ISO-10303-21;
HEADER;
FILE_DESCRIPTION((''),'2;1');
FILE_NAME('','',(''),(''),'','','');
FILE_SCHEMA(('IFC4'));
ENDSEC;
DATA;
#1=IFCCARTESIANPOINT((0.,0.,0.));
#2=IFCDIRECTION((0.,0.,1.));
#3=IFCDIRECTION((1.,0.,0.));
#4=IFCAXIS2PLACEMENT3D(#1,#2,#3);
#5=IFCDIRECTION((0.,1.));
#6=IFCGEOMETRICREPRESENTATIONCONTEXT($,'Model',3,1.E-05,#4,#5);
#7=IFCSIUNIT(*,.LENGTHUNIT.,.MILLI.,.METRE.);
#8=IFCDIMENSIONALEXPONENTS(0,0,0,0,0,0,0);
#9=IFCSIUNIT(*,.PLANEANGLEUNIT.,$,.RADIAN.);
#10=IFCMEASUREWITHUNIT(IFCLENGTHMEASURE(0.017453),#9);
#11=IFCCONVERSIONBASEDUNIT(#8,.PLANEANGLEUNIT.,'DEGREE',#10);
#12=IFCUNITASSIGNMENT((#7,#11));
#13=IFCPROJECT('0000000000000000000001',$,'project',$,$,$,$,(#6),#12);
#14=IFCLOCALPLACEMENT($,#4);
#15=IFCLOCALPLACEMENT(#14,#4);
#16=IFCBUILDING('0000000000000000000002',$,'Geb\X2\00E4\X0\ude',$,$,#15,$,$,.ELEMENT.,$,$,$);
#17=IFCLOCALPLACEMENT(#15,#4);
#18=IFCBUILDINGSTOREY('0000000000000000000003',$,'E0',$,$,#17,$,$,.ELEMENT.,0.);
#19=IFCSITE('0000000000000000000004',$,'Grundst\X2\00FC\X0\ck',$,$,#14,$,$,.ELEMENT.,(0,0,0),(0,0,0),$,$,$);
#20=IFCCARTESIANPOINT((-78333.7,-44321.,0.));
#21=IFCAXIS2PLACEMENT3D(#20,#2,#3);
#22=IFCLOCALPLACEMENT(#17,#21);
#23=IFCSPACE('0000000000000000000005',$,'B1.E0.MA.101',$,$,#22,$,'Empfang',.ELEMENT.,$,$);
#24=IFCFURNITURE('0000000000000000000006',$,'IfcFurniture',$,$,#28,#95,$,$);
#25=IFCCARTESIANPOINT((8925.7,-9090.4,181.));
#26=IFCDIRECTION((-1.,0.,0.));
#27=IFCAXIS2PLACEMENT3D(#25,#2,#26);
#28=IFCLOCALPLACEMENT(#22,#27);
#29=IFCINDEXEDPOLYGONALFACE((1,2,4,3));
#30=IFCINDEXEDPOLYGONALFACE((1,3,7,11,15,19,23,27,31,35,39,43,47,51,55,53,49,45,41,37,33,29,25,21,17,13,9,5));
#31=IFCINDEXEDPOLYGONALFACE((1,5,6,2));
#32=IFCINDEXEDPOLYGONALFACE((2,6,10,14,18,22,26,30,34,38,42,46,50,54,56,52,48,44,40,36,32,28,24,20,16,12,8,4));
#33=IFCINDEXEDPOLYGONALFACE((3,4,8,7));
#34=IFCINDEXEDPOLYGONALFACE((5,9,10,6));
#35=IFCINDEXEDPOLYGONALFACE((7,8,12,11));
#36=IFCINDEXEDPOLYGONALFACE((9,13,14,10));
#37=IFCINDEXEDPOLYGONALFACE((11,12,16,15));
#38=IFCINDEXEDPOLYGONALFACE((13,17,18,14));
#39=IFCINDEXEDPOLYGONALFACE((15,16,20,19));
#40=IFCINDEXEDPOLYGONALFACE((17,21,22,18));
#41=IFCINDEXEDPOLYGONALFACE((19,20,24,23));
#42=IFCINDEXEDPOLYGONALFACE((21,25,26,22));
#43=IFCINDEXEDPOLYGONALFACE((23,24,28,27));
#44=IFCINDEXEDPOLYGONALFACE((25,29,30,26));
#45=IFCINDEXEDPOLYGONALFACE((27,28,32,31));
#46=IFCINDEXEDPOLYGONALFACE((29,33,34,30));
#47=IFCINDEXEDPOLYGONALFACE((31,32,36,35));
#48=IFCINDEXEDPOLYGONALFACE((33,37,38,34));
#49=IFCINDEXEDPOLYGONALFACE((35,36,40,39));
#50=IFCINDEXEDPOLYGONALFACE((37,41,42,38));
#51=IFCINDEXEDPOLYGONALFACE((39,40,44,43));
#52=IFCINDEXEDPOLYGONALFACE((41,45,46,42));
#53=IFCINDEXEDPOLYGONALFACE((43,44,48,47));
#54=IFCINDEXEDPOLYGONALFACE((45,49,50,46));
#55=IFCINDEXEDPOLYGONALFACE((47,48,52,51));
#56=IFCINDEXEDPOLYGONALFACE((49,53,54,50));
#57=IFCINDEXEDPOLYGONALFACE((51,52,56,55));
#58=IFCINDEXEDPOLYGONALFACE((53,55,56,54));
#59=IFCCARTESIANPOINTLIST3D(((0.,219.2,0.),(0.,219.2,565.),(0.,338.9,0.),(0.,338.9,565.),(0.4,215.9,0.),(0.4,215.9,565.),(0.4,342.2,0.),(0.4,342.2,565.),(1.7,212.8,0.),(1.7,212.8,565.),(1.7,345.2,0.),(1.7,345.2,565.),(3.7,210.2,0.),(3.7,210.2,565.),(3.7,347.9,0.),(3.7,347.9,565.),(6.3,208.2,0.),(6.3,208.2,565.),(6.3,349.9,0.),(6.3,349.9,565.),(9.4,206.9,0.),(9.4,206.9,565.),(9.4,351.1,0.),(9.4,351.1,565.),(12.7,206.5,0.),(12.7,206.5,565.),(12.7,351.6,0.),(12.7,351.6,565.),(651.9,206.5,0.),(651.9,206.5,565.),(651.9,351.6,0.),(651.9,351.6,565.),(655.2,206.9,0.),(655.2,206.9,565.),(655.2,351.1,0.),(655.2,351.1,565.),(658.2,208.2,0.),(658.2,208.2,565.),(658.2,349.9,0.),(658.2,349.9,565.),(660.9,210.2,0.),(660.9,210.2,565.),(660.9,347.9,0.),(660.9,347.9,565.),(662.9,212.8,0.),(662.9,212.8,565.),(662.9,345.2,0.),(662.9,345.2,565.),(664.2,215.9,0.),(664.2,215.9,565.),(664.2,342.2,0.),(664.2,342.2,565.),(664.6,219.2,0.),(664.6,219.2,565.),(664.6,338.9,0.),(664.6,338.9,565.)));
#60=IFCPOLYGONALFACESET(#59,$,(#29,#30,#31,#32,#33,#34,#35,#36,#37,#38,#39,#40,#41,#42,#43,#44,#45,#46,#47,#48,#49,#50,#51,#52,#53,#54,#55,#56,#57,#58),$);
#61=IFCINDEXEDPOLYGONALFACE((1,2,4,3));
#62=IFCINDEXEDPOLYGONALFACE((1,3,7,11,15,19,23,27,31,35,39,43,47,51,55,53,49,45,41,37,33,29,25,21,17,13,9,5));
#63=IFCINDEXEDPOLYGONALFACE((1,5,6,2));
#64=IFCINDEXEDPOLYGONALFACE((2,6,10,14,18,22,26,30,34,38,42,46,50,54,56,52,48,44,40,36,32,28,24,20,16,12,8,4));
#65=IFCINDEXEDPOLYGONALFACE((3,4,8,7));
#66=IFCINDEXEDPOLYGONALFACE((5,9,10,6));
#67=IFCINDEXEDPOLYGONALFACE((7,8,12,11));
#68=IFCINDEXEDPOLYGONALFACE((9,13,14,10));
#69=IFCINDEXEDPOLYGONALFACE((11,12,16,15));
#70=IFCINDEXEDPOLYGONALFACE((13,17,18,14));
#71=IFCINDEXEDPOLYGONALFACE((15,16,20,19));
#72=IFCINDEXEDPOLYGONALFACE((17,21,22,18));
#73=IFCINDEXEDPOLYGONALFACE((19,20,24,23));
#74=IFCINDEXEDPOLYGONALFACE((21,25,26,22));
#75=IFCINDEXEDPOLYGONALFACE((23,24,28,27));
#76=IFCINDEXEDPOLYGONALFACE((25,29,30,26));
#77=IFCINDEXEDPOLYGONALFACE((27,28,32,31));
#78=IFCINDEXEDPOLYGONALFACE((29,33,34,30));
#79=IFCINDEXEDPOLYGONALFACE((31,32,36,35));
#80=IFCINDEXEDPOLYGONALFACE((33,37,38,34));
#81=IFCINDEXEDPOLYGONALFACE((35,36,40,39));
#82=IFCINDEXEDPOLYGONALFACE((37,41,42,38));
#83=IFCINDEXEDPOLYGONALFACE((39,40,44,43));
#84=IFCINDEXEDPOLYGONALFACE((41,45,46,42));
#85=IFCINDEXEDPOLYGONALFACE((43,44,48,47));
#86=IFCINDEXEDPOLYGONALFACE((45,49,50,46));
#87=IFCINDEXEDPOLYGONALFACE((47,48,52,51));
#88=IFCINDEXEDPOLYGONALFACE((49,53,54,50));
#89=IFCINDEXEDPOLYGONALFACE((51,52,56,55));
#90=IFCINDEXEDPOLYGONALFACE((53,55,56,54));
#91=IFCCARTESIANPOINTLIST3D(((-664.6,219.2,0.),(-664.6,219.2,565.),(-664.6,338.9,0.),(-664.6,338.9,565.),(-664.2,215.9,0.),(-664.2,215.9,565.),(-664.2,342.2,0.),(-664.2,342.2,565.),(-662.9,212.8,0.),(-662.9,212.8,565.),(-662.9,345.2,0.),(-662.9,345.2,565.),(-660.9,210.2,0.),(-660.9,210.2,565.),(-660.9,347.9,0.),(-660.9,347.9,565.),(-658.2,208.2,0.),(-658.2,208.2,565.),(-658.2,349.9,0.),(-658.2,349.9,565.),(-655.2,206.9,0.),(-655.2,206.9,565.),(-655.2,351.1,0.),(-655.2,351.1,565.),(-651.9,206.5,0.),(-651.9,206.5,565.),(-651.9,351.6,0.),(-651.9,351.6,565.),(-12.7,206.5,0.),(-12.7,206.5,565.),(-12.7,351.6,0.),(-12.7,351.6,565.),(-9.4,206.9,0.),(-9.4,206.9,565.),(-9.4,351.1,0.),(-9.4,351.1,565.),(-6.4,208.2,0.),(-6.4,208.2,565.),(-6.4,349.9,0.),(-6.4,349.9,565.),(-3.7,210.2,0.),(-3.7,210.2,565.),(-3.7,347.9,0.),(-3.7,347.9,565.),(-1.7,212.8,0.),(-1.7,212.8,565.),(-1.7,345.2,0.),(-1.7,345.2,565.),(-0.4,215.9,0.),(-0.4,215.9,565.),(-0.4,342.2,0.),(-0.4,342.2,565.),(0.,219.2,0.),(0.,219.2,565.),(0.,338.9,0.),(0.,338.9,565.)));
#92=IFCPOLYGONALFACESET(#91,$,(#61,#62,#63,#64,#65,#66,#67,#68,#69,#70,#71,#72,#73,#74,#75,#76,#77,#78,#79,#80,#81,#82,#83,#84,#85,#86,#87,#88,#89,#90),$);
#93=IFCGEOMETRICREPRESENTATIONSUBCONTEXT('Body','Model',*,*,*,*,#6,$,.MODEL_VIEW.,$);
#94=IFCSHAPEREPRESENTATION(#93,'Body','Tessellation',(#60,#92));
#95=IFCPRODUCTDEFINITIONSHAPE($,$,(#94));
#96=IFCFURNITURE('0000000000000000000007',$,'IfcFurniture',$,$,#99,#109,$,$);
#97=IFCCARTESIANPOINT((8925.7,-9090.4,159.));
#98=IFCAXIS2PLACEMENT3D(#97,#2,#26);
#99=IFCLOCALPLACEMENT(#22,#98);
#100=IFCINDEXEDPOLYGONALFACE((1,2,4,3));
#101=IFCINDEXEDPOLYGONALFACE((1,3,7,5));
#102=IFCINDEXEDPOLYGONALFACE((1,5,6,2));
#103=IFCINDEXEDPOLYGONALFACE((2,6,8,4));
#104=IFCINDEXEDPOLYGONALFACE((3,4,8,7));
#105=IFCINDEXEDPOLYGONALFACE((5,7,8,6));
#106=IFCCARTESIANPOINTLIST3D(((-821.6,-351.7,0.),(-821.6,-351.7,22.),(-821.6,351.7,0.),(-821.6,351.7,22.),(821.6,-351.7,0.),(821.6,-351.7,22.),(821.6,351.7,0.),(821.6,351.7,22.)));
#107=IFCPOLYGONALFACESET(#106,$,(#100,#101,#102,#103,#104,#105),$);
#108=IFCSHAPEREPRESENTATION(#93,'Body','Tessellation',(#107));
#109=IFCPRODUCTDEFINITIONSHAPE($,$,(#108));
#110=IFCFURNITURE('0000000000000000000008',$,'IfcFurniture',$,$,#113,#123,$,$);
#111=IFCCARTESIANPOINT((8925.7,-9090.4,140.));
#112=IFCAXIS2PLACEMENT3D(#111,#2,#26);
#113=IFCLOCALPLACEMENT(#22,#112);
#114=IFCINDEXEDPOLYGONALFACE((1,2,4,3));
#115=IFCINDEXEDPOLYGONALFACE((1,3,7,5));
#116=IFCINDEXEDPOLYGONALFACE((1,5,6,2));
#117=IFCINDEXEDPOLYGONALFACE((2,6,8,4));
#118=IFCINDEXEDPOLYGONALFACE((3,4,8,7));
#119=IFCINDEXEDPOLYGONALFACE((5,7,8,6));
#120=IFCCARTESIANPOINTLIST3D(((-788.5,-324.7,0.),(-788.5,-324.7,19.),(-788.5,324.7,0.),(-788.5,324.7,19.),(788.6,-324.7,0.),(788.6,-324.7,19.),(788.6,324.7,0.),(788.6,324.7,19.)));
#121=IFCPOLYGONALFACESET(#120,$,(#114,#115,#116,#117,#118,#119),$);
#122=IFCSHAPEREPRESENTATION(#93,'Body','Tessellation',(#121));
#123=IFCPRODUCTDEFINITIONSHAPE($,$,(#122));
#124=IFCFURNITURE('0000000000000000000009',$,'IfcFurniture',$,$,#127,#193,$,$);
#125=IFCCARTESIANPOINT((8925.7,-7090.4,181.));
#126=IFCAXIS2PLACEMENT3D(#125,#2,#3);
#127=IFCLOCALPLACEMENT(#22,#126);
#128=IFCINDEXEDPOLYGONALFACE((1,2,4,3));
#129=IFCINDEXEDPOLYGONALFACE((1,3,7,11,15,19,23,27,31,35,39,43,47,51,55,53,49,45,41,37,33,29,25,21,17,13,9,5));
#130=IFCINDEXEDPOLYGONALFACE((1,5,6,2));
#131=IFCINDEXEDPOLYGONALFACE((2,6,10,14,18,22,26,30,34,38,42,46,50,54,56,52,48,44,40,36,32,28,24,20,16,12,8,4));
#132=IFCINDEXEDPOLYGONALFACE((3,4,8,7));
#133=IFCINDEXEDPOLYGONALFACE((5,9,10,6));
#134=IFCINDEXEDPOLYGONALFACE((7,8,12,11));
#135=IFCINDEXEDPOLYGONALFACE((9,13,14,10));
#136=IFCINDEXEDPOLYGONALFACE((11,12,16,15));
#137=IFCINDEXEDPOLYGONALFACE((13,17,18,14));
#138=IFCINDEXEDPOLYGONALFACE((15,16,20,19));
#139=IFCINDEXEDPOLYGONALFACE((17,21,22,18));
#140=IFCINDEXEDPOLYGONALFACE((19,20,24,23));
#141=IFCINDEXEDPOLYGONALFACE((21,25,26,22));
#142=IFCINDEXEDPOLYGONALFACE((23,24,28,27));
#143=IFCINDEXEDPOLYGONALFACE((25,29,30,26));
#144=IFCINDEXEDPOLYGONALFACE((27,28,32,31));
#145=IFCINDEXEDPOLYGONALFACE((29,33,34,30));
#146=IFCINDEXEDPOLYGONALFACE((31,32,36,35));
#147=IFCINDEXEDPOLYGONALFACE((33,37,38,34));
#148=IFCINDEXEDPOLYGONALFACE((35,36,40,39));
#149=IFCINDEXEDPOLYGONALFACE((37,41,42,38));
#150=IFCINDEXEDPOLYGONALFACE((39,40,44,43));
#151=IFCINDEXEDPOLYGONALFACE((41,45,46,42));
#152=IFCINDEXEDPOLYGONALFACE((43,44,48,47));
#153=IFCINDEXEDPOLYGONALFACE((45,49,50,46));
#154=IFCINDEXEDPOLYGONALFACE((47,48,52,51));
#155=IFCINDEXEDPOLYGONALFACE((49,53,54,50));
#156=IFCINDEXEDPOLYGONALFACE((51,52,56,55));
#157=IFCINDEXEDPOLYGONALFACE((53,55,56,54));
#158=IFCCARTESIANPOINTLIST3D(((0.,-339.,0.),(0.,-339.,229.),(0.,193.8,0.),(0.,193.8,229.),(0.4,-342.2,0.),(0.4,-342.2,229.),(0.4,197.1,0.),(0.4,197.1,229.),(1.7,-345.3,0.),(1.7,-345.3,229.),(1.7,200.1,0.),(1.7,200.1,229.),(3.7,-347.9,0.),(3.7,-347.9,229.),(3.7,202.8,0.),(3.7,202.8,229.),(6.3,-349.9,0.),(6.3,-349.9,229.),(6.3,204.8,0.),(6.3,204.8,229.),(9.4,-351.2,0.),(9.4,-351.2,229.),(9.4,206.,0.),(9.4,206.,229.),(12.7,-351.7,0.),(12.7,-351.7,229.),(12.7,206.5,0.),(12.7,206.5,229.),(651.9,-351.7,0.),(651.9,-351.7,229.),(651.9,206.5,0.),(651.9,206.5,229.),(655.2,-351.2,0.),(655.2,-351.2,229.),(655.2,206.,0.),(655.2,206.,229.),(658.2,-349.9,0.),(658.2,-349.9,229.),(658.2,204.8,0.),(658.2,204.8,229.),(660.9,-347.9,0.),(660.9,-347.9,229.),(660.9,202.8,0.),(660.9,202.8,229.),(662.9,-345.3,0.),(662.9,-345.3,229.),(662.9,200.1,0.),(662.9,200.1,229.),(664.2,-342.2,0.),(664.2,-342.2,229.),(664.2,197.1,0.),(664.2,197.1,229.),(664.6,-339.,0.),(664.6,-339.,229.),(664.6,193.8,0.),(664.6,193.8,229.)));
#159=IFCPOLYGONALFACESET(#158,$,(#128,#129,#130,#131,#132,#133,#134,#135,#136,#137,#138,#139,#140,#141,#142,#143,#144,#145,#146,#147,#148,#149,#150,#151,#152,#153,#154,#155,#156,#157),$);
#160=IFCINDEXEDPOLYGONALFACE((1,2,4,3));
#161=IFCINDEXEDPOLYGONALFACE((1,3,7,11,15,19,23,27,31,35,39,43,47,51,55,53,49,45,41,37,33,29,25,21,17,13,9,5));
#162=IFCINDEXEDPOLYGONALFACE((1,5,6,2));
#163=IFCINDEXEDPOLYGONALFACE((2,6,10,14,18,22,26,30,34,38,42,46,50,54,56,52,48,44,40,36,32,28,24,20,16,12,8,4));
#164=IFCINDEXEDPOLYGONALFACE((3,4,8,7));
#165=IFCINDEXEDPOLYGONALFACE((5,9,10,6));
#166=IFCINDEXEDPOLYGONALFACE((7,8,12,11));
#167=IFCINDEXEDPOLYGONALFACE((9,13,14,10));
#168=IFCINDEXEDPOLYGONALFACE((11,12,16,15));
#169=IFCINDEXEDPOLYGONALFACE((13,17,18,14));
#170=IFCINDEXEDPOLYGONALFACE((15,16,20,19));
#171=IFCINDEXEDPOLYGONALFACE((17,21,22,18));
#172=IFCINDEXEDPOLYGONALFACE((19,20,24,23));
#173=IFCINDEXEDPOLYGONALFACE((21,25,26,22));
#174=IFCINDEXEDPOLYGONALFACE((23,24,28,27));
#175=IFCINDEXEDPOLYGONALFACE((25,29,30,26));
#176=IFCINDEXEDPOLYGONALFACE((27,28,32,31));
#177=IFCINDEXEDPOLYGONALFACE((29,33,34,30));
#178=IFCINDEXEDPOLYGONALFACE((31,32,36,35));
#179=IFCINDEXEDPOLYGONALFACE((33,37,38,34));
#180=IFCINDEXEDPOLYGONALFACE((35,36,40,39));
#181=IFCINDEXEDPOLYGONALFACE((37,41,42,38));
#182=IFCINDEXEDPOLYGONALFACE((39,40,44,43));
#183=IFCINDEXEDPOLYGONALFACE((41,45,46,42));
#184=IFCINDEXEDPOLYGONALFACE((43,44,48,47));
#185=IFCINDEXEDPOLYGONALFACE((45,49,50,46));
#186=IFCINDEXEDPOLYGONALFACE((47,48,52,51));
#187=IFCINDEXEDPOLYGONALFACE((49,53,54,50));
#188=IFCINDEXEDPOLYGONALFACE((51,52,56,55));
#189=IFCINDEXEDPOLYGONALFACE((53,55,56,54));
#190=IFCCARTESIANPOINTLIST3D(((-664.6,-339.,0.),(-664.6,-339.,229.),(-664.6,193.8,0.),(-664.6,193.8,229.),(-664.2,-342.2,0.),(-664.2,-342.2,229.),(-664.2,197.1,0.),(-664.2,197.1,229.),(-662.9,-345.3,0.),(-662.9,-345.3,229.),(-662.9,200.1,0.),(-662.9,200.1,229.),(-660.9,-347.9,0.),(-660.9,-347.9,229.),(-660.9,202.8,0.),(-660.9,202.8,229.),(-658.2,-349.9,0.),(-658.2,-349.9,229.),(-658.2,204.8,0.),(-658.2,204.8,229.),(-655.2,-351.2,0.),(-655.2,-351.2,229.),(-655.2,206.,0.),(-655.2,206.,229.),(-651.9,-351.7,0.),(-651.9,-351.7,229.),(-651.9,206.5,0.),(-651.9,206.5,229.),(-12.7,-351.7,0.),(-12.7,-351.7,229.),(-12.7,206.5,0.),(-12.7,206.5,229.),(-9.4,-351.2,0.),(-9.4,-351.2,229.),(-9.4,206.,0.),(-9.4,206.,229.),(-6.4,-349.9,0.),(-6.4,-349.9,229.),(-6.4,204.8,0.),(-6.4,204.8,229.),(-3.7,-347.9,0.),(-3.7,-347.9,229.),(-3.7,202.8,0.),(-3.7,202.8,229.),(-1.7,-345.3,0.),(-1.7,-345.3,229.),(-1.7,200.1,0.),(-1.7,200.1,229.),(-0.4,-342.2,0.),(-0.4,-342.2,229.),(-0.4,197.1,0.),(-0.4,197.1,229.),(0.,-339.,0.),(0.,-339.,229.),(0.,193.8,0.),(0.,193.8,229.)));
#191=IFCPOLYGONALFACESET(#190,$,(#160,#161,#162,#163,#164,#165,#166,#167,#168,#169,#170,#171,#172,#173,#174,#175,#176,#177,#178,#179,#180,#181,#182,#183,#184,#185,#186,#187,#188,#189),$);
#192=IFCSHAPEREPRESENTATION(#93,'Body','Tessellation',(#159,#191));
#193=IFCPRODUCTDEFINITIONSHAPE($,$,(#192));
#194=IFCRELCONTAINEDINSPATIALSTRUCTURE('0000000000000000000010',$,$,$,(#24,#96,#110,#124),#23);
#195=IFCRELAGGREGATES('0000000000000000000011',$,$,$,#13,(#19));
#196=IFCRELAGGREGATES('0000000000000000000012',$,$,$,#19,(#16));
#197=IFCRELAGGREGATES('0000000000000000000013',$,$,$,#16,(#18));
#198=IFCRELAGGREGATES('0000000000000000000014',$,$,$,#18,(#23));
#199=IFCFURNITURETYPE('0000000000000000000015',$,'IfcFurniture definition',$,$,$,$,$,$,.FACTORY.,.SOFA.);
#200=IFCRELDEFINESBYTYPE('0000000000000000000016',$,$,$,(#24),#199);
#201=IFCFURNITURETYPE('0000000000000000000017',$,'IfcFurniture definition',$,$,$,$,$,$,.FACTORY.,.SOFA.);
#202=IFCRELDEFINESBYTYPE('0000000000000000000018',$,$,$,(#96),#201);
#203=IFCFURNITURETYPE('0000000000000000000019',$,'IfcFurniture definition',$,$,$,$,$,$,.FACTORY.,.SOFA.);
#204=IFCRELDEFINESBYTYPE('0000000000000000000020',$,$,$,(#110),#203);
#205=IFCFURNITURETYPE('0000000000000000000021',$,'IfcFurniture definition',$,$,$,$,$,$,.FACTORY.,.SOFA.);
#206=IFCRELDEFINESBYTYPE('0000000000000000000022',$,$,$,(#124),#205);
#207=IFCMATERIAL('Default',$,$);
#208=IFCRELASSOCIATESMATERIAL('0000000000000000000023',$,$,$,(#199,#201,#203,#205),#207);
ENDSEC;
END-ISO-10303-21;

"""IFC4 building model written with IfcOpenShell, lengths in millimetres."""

from ifc_helpers import new_model, entity, si_unit, converted_unit, direction, frame, origin_with_axes, place, context, subcontext, project, spatial, line, arc, indexed_curve, outline, extrude, material, type_object, element, save


model = new_model("IFC4")

# Units and contexts
model_context = context("Model", 3, precision=1e-05, world=origin_with_axes(), true_north=direction((0.0, 1.0)))
body_context = subcontext(model_context, "Body", "Model", "MODEL_VIEW")
ifc_project = project(units=[si_unit("LENGTHUNIT", "METRE", prefix="MILLI"), converted_unit("PLANEANGLEUNIT", "DEGREE", entity("IfcLengthMeasure", 0.017453), si_unit("PLANEANGLEUNIT", "RADIAN"), dimensions=[0, 0, 0, 0, 0, 0, 0])], contexts=[model_context])

# Site, building, storey
site_placement = place(None, origin_with_axes())
site = spatial("IfcSite", under=ifc_project, at=site_placement, Name="Grundstück", CompositionType="ELEMENT", RefLatitude=(0, 0, 0), RefLongitude=(0, 0, 0))
building_placement = place(site_placement, origin_with_axes())
building = spatial("IfcBuilding", under=site, at=building_placement, Name="Gebäude", CompositionType="ELEMENT")
storey_placement = place(building_placement, origin_with_axes())
storey = spatial("IfcBuildingStorey", under=building, at=storey_placement, Name="E0", CompositionType="ELEMENT", Elevation=0.0)

# Shared definitions
space_1_placement = place(storey_placement, frame((-78333.7, -44321.0, 0.0), z_axis=(0.0, 0.0, 1.0), x_axis=(1.0, 0.0, 0.0)))
space_1 = spatial("IfcSpace", under=storey, at=space_1_placement, Name="B1.E0.MA.101", LongName="Empfang", CompositionType="ELEMENT")

# Furniture
ifc_material_1 = material(Name="Default")
furniture_type_1 = type_object("IfcFurnitureType", Name="IfcFurniture definition", AssemblyPlace="FACTORY", PredefinedType="SOFA", material=ifc_material_1)
furniture_1_placement = place(space_1_placement, frame((8925.7, -9090.4, 181.0), z_axis=(0.0, 0.0, 1.0), x_axis=(-1.0, 0.0, 0.0)))
element("IfcFurniture", 1, at=furniture_1_placement, inside=space_1, type_object=furniture_type_1, Name="IfcFurniture", context=body_context, shape_type="SweptSolid", body=[
    extrude(outline(indexed_curve([(651.9, 351.6), (660.9, 347.9), (664.6, 338.9), (664.6, 219.2), (660.9, 210.2), (651.9, 206.5), (12.7, 206.5), (3.7, 210.2), (0.0, 219.2), (0.0, 338.9), (3.7, 347.9), (12.7, 351.6)], segments=[arc(1, 2, 3), line(3, 4), arc(4, 5, 6), line(6, 7), arc(7, 8, 9), line(9, 10), arc(10, 11, 12), line(12, 1)])), origin_with_axes(), (0.0, 0.0, 1.0), 565.0),
    extrude(outline(indexed_curve([(-651.9, 351.6), (-660.9, 347.9), (-664.6, 338.9), (-664.6, 219.2), (-660.9, 210.2), (-651.9, 206.5), (-12.7, 206.5), (-3.7, 210.2), (0.0, 219.2), (0.0, 338.9), (-3.7, 347.9), (-12.7, 351.6)], segments=[arc(1, 2, 3), line(3, 4), arc(4, 5, 6), line(6, 7), arc(7, 8, 9), line(9, 10), arc(10, 11, 12), line(12, 1)])), origin_with_axes(), (0.0, 0.0, 1.0), 565.0),
])
furniture_type_2 = type_object("IfcFurnitureType", Name="IfcFurniture definition", AssemblyPlace="FACTORY", PredefinedType="SOFA", material=ifc_material_1)
furniture_2_placement = place(space_1_placement, frame((8925.7, -9090.4, 159.0), z_axis=(0.0, 0.0, 1.0), x_axis=(-1.0, 0.0, 0.0)))
element("IfcFurniture", 2, at=furniture_2_placement, inside=space_1, type_object=furniture_type_2, Name="IfcFurniture", context=body_context, shape_type="SweptSolid", body=[
    extrude(outline(indexed_curve([(-821.6, -351.7), (-821.6, 351.7), (821.6, 351.7), (821.6, -351.7)], segments=[line(1, 2), line(2, 3), line(3, 4), line(4, 1)])), origin_with_axes(), (0.0, 0.0, 1.0), 22.0),
])
furniture_type_3 = type_object("IfcFurnitureType", Name="IfcFurniture definition", AssemblyPlace="FACTORY", PredefinedType="SOFA", material=ifc_material_1)
furniture_3_placement = place(space_1_placement, frame((8925.7, -9090.4, 140.0), z_axis=(0.0, 0.0, 1.0), x_axis=(-1.0, 0.0, 0.0)))
element("IfcFurniture", 3, at=furniture_3_placement, inside=space_1, type_object=furniture_type_3, Name="IfcFurniture", context=body_context, shape_type="SweptSolid", body=[
    extrude(outline(indexed_curve([(-788.5, -324.7), (-788.5, 324.7), (788.6, 324.7), (788.6, -324.7)], segments=[line(1, 2), line(2, 3), line(3, 4), line(4, 1)])), origin_with_axes(), (0.0, 0.0, 1.0), 19.0),
])
furniture_type_4 = type_object("IfcFurnitureType", Name="IfcFurniture definition", AssemblyPlace="FACTORY", PredefinedType="SOFA", material=ifc_material_1)
furniture_4_placement = place(space_1_placement, frame((8925.7, -7090.4, 181.0), z_axis=(0.0, 0.0, 1.0), x_axis=(1.0, 0.0, 0.0)))
element("IfcFurniture", 4, at=furniture_4_placement, inside=space_1, type_object=furniture_type_4, Name="IfcFurniture", context=body_context, shape_type="SweptSolid", body=[
    extrude(outline(indexed_curve([(651.9, 206.5), (660.9, 202.8), (664.6, 193.8), (664.6, -339.0), (660.9, -347.9), (651.9, -351.7), (12.7, -351.7), (3.7, -347.9), (0.0, -339.0), (0.0, 193.8), (3.7, 202.8), (12.7, 206.5)], segments=[arc(1, 2, 3), line(3, 4), arc(4, 5, 6), line(6, 7), arc(7, 8, 9), line(9, 10), arc(10, 11, 12), line(12, 1)])), origin_with_axes(), (0.0, 0.0, 1.0), 229.0),
    extrude(outline(indexed_curve([(-651.9, 206.5), (-660.9, 202.8), (-664.6, 193.8), (-664.6, -339.0), (-660.9, -347.9), (-651.9, -351.7), (-12.7, -351.7), (-3.7, -347.9), (0.0, -339.0), (0.0, 193.8), (-3.7, 202.8), (-12.7, 206.5)], segments=[arc(1, 2, 3), line(3, 4), arc(4, 5, 6), line(6, 7), arc(7, 8, 9), line(9, 10), arc(10, 11, 12), line(12, 1)])), origin_with_axes(), (0.0, 0.0, 1.0), 229.0),
])

save(model, "model.ifc")
